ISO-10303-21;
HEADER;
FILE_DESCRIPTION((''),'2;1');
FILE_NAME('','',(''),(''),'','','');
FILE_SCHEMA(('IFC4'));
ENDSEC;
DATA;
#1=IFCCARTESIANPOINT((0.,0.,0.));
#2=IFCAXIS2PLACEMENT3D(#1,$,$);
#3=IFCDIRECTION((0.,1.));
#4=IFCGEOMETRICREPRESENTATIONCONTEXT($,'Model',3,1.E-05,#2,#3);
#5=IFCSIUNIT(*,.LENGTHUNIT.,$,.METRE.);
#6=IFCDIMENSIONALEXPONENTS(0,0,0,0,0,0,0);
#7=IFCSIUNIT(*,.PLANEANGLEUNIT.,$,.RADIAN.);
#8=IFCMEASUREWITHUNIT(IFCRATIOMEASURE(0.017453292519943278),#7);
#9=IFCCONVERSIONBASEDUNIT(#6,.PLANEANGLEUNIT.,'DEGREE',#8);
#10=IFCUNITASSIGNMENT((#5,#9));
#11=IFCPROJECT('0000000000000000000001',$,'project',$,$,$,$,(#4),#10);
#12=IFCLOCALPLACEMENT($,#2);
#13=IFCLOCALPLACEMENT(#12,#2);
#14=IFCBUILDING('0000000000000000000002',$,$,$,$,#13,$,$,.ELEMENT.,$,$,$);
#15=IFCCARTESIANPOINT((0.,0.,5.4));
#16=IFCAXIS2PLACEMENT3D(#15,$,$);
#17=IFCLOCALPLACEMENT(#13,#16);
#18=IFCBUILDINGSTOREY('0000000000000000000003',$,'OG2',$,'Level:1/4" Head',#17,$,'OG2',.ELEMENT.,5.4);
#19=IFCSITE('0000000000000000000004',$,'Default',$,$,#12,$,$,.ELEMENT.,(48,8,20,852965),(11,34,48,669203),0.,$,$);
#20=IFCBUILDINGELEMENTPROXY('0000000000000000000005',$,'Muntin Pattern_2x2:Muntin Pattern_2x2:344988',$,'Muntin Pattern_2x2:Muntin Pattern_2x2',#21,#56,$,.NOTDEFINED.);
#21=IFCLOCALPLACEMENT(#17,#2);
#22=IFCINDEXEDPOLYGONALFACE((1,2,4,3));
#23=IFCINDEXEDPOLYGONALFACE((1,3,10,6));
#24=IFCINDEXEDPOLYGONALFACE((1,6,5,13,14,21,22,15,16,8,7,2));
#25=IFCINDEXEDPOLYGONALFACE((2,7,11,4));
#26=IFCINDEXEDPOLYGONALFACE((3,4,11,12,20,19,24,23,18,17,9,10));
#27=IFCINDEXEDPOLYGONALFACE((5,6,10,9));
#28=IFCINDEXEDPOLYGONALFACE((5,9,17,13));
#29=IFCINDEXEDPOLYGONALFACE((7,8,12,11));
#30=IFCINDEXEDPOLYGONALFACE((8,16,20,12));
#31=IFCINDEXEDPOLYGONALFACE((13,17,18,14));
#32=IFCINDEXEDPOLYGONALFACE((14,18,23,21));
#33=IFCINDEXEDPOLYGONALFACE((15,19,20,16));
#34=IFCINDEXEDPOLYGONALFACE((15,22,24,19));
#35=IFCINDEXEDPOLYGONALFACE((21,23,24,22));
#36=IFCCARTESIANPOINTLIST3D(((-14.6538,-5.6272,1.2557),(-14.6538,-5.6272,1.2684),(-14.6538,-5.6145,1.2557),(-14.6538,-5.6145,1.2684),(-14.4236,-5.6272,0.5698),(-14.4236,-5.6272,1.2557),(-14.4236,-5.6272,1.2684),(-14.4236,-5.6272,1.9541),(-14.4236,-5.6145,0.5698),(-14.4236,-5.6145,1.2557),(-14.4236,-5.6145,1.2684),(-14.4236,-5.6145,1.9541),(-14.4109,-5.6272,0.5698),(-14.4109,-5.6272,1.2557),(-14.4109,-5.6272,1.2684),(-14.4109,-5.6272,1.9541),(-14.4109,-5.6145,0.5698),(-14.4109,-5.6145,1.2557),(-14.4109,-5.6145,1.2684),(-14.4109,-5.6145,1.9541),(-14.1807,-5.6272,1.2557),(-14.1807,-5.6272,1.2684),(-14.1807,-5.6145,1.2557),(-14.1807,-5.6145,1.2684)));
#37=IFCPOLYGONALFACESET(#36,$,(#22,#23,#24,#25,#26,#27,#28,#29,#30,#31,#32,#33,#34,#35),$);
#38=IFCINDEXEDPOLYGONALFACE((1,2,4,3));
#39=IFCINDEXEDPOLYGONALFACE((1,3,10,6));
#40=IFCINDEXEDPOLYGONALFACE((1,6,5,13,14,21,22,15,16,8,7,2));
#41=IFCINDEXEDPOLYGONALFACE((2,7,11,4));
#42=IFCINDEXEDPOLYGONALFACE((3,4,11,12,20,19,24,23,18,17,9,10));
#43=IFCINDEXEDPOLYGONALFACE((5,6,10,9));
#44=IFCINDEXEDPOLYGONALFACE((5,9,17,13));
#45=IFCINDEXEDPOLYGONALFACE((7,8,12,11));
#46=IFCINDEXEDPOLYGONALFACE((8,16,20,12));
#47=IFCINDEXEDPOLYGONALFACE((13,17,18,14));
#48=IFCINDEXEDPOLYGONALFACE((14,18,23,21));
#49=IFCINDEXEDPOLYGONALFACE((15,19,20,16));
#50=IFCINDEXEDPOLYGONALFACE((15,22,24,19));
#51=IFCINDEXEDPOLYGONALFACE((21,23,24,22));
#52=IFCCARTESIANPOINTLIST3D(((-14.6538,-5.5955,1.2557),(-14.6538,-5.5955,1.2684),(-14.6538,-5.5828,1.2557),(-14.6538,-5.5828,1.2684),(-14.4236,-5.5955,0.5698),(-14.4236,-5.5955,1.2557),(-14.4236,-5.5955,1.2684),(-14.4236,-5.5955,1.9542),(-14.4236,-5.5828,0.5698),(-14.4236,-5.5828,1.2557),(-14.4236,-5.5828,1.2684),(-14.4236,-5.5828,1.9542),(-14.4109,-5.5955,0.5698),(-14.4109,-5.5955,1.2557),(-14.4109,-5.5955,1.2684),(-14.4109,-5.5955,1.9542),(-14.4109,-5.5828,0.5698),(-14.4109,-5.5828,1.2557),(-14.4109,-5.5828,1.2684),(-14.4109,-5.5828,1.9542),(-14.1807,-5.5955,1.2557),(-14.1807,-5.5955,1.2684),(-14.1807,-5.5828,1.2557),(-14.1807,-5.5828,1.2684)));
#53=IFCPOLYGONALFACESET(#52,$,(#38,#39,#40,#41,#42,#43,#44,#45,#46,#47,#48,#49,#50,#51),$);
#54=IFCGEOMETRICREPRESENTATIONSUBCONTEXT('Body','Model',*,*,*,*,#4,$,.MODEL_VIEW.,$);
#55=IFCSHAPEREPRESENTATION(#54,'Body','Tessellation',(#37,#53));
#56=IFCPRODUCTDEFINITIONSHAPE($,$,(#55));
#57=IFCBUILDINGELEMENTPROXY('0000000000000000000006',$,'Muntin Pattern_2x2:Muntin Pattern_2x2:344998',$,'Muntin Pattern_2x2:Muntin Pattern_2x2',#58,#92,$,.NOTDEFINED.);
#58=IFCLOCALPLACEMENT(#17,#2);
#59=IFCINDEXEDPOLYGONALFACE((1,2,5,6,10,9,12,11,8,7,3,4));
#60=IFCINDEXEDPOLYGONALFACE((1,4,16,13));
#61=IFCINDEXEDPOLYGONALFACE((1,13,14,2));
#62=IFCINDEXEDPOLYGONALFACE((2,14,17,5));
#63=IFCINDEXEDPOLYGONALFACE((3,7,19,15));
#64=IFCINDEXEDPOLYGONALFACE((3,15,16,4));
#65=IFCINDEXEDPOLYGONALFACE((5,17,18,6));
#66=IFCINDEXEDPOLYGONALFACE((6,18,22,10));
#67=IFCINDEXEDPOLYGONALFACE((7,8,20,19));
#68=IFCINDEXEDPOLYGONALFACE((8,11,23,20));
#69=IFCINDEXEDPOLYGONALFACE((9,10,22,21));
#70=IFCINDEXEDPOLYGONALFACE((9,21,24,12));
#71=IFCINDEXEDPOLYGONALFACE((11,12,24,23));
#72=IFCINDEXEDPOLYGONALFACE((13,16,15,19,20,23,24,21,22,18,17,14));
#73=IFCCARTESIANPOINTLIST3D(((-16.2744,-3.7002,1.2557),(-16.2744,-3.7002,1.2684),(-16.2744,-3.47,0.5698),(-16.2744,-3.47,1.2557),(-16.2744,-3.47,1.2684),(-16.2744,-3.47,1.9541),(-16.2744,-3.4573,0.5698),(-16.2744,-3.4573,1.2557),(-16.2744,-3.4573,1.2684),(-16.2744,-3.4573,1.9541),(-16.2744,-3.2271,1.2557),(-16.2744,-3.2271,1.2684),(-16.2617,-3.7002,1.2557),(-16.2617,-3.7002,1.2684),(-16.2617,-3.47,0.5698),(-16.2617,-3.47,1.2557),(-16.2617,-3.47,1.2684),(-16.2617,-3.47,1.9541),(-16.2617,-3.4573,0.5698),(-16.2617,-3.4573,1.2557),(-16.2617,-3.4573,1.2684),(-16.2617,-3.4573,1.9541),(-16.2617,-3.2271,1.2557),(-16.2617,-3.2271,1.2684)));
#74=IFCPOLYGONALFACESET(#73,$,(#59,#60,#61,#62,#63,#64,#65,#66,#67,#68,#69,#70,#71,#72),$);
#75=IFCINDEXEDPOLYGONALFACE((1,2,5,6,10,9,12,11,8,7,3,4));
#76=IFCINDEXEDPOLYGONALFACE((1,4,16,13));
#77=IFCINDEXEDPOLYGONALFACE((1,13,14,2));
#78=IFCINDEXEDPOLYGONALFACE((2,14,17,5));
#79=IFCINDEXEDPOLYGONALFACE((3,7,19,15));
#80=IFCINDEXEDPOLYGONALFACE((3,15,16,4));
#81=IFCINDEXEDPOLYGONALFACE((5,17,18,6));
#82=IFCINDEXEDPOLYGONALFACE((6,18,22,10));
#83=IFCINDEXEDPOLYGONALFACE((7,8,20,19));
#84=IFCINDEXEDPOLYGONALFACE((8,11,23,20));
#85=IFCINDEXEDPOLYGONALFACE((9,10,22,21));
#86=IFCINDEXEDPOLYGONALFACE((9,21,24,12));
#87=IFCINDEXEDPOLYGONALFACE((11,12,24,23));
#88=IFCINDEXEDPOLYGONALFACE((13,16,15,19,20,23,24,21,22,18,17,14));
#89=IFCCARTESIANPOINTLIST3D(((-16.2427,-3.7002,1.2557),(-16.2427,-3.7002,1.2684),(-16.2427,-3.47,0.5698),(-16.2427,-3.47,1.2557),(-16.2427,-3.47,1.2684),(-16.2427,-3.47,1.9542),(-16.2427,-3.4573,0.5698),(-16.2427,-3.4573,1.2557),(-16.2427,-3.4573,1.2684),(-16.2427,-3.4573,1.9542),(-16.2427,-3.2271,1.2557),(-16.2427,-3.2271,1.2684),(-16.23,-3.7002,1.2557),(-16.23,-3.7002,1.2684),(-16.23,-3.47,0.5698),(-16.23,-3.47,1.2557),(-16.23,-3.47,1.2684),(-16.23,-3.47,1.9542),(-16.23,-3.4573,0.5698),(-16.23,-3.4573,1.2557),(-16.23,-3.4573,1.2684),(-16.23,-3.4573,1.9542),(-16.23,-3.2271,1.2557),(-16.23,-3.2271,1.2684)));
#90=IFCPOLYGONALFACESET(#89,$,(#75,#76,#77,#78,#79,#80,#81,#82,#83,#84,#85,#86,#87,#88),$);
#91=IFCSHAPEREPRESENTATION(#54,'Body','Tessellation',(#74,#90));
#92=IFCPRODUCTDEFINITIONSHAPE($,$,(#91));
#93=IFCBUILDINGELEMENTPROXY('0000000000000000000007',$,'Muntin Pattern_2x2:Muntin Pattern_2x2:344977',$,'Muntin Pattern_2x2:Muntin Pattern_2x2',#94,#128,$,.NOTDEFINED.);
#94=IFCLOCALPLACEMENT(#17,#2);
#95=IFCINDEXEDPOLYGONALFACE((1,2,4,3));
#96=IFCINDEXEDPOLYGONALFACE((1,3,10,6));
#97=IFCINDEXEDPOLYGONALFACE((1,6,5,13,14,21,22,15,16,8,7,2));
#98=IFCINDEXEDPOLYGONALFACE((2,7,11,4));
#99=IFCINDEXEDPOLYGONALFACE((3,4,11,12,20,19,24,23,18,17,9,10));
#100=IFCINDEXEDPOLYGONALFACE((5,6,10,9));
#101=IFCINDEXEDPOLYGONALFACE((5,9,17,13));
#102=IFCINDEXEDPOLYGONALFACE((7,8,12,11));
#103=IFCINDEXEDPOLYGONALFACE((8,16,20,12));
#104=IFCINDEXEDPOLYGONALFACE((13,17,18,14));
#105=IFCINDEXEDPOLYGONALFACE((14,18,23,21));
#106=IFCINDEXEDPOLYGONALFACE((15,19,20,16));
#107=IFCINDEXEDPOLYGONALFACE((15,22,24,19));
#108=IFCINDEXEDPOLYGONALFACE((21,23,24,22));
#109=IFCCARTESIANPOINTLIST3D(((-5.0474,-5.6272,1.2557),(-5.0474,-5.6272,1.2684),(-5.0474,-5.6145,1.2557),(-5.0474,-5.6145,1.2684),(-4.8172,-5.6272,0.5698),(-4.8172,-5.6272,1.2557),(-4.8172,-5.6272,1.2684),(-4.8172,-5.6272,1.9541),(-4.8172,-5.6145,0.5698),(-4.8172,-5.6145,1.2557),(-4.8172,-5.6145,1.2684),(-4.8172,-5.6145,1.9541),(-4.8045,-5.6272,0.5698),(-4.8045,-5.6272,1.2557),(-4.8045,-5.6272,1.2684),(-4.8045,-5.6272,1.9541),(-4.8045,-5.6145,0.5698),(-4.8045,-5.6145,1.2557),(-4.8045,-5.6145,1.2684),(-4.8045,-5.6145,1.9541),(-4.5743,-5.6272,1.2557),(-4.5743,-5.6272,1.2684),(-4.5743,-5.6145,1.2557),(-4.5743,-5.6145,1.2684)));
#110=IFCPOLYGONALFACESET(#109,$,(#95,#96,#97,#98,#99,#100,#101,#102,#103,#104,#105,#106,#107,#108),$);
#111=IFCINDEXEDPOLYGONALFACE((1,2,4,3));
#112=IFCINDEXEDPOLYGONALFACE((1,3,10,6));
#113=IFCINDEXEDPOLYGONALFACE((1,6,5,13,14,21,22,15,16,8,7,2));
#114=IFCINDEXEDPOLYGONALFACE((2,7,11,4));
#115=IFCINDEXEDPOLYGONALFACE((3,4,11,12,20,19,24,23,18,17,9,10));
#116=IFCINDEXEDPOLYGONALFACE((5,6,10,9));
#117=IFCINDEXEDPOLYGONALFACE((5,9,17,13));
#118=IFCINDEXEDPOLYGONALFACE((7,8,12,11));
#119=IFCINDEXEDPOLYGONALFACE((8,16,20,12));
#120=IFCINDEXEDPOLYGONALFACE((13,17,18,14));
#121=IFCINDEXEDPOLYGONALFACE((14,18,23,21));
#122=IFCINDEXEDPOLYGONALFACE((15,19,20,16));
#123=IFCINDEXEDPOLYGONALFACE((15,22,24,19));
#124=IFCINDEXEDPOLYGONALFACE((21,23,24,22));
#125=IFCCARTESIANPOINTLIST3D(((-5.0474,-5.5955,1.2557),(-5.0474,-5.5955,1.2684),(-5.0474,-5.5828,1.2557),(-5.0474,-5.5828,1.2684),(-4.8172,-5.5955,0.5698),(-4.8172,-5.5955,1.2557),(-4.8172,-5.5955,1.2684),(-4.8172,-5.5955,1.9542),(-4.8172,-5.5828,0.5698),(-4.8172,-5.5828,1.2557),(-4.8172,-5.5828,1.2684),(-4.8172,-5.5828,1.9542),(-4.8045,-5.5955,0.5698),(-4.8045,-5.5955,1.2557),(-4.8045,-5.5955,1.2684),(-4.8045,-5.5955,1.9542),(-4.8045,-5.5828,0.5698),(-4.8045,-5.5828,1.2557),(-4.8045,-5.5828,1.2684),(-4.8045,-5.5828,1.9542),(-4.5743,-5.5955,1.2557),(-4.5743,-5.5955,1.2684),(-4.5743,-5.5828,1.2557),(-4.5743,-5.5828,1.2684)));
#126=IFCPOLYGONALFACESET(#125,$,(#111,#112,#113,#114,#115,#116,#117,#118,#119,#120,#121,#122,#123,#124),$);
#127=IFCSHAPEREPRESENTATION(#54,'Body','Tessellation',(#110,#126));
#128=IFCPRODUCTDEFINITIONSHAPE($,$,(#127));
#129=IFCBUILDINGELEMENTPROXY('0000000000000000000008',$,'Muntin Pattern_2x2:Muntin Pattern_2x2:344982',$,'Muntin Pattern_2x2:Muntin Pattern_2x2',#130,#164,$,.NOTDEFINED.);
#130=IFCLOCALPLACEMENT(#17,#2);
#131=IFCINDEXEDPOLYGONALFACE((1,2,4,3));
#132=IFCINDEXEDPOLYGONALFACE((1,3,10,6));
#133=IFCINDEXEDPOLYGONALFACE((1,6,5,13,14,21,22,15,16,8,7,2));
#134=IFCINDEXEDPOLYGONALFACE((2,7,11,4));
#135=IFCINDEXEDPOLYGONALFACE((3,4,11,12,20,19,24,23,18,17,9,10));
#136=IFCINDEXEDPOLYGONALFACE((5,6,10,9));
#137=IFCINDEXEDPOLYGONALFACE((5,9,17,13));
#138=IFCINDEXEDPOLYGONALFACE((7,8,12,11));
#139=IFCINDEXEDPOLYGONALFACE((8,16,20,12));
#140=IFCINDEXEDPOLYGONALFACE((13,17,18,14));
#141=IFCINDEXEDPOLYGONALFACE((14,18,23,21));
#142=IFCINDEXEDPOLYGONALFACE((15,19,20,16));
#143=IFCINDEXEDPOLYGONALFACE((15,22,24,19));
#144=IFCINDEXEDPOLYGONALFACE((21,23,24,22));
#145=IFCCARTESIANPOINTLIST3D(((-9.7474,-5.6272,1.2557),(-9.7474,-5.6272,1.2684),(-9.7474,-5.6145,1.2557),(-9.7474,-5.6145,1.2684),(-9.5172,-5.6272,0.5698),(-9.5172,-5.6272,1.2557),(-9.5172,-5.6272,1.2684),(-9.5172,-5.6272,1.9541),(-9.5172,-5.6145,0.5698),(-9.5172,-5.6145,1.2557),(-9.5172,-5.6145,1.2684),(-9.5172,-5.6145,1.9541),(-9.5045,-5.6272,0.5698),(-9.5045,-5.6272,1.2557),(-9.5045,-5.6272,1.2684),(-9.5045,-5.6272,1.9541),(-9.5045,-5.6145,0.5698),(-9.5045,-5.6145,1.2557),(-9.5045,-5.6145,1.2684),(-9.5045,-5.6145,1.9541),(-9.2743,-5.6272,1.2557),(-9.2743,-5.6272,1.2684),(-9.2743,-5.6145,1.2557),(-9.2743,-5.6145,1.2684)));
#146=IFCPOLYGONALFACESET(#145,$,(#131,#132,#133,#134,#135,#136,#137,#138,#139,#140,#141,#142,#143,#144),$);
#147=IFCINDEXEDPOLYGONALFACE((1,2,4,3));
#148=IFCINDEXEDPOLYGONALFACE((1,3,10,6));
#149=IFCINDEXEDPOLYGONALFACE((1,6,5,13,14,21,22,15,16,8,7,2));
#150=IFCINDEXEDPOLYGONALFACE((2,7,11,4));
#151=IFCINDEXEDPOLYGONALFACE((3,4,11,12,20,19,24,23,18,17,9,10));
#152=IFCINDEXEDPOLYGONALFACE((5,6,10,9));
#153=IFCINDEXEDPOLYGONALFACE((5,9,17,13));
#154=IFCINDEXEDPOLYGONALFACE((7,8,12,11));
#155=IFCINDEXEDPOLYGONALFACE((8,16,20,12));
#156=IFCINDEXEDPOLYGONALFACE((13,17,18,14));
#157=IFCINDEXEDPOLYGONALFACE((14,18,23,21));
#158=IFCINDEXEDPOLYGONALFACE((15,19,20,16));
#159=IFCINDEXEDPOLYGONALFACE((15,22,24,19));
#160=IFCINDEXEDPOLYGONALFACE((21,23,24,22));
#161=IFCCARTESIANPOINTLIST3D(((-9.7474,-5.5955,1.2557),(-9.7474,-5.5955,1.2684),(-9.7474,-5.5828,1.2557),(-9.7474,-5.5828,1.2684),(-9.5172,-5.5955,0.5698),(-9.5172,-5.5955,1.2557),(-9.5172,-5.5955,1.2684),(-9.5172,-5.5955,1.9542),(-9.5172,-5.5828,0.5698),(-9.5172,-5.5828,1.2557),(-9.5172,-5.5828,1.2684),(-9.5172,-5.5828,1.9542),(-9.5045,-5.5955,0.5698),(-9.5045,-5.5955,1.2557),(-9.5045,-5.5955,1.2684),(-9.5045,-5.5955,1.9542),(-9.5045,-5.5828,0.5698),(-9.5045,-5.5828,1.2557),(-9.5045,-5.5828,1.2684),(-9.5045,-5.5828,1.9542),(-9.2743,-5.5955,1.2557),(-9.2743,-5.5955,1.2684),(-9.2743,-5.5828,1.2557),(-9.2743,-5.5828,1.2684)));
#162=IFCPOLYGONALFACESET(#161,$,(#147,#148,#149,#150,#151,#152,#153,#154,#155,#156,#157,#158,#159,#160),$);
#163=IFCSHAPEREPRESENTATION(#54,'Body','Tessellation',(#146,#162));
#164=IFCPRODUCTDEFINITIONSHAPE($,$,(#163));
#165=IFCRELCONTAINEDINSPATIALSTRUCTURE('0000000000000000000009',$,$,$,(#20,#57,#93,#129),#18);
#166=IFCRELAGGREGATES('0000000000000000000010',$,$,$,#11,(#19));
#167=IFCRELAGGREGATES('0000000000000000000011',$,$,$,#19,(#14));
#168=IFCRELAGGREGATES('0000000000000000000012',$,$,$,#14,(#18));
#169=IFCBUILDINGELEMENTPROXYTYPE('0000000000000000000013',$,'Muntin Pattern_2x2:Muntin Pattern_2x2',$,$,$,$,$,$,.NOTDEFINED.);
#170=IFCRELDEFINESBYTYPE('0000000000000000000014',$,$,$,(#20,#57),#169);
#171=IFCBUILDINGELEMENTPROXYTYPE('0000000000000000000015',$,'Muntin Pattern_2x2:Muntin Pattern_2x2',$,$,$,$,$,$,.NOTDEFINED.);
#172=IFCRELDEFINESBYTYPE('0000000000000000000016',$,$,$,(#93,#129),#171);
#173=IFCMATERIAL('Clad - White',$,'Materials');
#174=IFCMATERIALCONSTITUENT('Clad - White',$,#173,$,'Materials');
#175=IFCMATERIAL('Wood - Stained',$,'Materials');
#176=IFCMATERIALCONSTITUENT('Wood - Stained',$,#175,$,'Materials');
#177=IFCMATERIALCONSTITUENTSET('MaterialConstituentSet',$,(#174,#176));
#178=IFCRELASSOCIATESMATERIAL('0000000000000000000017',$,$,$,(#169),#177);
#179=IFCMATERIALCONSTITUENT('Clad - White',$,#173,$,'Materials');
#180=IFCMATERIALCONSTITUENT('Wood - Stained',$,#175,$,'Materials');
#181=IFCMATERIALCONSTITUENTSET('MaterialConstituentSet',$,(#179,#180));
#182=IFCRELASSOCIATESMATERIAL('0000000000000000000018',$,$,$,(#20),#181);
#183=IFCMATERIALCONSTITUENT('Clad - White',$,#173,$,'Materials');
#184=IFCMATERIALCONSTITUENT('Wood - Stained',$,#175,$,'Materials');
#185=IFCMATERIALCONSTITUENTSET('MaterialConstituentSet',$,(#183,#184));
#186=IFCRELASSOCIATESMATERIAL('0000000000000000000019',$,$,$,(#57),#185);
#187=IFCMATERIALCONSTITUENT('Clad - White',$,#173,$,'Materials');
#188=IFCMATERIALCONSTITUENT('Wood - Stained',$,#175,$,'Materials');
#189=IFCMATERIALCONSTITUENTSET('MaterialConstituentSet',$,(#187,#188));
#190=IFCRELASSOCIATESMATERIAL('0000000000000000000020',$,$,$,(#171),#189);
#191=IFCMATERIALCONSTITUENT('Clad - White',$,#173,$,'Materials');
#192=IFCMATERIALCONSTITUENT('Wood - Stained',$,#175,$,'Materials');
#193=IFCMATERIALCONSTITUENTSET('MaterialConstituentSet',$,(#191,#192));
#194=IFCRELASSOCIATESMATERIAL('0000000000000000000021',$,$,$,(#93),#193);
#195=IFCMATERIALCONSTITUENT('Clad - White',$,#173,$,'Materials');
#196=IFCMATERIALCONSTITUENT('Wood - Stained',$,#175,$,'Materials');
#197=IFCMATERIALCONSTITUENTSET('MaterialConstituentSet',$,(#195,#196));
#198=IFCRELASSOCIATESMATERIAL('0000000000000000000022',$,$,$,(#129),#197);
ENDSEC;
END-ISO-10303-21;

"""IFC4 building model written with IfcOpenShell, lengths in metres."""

from ifc_helpers import new_model, entity, si_unit, converted_unit, direction, frame, origin, place, context, subcontext, project, spatial, indexed_curve, outline, extrude, source, transform, mapped, material, constituent, constituent_set, type_object, type_shapes, element, save


model = new_model("IFC4")

# Units and contexts
model_context = context("Model", 3, precision=1e-05, world=origin(), true_north=direction((0.0, 1.0)))
body_context = subcontext(model_context, "Body", "Model", "MODEL_VIEW")
ifc_project = project(units=[si_unit("LENGTHUNIT", "METRE"), converted_unit("PLANEANGLEUNIT", "DEGREE", entity("IfcRatioMeasure", 0.017453292519943278), si_unit("PLANEANGLEUNIT", "RADIAN"), dimensions=[0, 0, 0, 0, 0, 0, 0])], contexts=[model_context])

# Site, building, storey
site_placement = place(None, origin())
site = spatial("IfcSite", under=ifc_project, at=site_placement, Name="Default", CompositionType="ELEMENT", RefLatitude=(48, 8, 20, 852965), RefLongitude=(11, 34, 48, 669203), RefElevation=0.0)
building_placement = place(site_placement, origin())
building = spatial("IfcBuilding", under=site, at=building_placement, CompositionType="ELEMENT")
storey_placement = place(building_placement, frame((0.0, 0.0, 5.4)))
storey = spatial("IfcBuildingStorey", under=building, at=storey_placement, Name="OG2", ObjectType="Level:1/4\" Head", LongName="OG2", CompositionType="ELEMENT", Elevation=5.4)

# Building element proxies
ifc_material_1 = material(Name="Clad - White", Category="Materials")
ifc_material_2 = material(Name="Wood - Stained", Category="Materials")
ifc_constituent_1 = constituent(ifc_material_1, Name="Clad - White", Category="Materials")
ifc_constituent_2 = constituent(ifc_material_2, Name="Wood - Stained", Category="Materials")
ifc_constituent_set_1 = constituent_set(constituents=[ifc_constituent_1, ifc_constituent_2], Name="MaterialConstituentSet")
building_element_proxy_type_1 = type_object("IfcBuildingElementProxyType", Name="Muntin Pattern_2x2:Muntin Pattern_2x2", PredefinedType="NOTDEFINED", material=ifc_constituent_set_1)
shared_shape_1 = source(origin(), body_context, "Body", "SweptSolid", [
    extrude(outline(indexed_curve([(0.0064, -0.0064), (0.6921, -0.0064), (0.6921, 0.0063), (0.0064, 0.0063), (0.0064, 0.2365), (-0.0063, 0.2365), (-0.0063, 0.0063), (-0.6922, 0.0063), (-0.6922, -0.0064), (-0.0063, -0.0064), (-0.0063, -0.2365), (0.0064, -0.2365), (0.0064, -0.0064)], self_intersect=False)), frame((0.0, -0.0222, 0.6921), z_axis=(0.0, 1.0, 0.0), x_axis=(0.0, 0.0, 1.0)), (0.0, 0.0, 1.0), 0.0127),
    extrude(outline(indexed_curve([(0.0064, -0.0064), (0.6922, -0.0064), (0.6922, 0.0063), (0.0064, 0.0063), (0.0064, 0.2365), (-0.0063, 0.2365), (-0.0063, 0.0063), (-0.6922, 0.0063), (-0.6922, -0.0064), (-0.0063, -0.0064), (-0.0063, -0.2365), (0.0064, -0.2365), (0.0064, -0.0064)], self_intersect=False)), frame((0.0, 0.0095, 0.6922), z_axis=(0.0, 1.0, 0.0), x_axis=(0.0, 0.0, 1.0)), (0.0, 0.0, 1.0), 0.0127),
])
type_shapes(building_element_proxy_type_1, [shared_shape_1])
ifc_constituent_3 = constituent(ifc_material_1, Name="Clad - White", Category="Materials")
ifc_constituent_4 = constituent(ifc_material_2, Name="Wood - Stained", Category="Materials")
ifc_constituent_set_2 = constituent_set(constituents=[ifc_constituent_3, ifc_constituent_4], Name="MaterialConstituentSet")
proxy_1_placement = place(storey_placement, frame((-14.4173, -5.605, 0.5699)))
element("IfcBuildingElementProxy", 1, at=proxy_1_placement, inside=storey, type_object=building_element_proxy_type_1, material=ifc_constituent_set_2, Name="Muntin Pattern_2x2:Muntin Pattern_2x2:344988", ObjectType="Muntin Pattern_2x2:Muntin Pattern_2x2", PredefinedType="NOTDEFINED", context=body_context, shape_type="MappedRepresentation", body=[
    mapped(shared_shape_1, transform((0.0, 0.0, 0.0), scale=1.0)),
])
ifc_constituent_5 = constituent(ifc_material_1, Name="Clad - White", Category="Materials")
ifc_constituent_6 = constituent(ifc_material_2, Name="Wood - Stained", Category="Materials")
ifc_constituent_set_3 = constituent_set(constituents=[ifc_constituent_5, ifc_constituent_6], Name="MaterialConstituentSet")
proxy_2_placement = place(storey_placement, frame((-16.2522, -3.4636, 0.5699), z_axis=(0.0, 0.0, 1.0), x_axis=(0.0, -1.0, 0.0)))
element("IfcBuildingElementProxy", 2, at=proxy_2_placement, inside=storey, type_object=building_element_proxy_type_1, material=ifc_constituent_set_3, Name="Muntin Pattern_2x2:Muntin Pattern_2x2:344998", ObjectType="Muntin Pattern_2x2:Muntin Pattern_2x2", PredefinedType="NOTDEFINED", context=body_context, shape_type="MappedRepresentation", body=[
    mapped(shared_shape_1, transform((0.0, 0.0, 0.0), scale=1.0)),
])
ifc_constituent_7 = constituent(ifc_material_1, Name="Clad - White", Category="Materials")
ifc_constituent_8 = constituent(ifc_material_2, Name="Wood - Stained", Category="Materials")
ifc_constituent_set_4 = constituent_set(constituents=[ifc_constituent_7, ifc_constituent_8], Name="MaterialConstituentSet")
ifc_constituent_9 = constituent(ifc_material_1, Name="Clad - White", Category="Materials")
ifc_constituent_10 = constituent(ifc_material_2, Name="Wood - Stained", Category="Materials")
ifc_constituent_set_5 = constituent_set(constituents=[ifc_constituent_9, ifc_constituent_10], Name="MaterialConstituentSet")
building_element_proxy_type_2 = type_object("IfcBuildingElementProxyType", Name="Muntin Pattern_2x2:Muntin Pattern_2x2", PredefinedType="NOTDEFINED", material=ifc_constituent_set_5)
shared_shape_2 = source(origin(), body_context, "Body", "SweptSolid", [
    extrude(outline(indexed_curve([(0.0064, -0.0064), (0.6921, -0.0064), (0.6921, 0.0063), (0.0064, 0.0063), (0.0064, 0.2365), (-0.0063, 0.2365), (-0.0063, 0.0063), (-0.6922, 0.0063), (-0.6922, -0.0064), (-0.0063, -0.0064), (-0.0063, -0.2365), (0.0064, -0.2365), (0.0064, -0.0064)], self_intersect=False)), frame((0.0, 0.0095, 0.6921), z_axis=(0.0, 1.0, 0.0), x_axis=(0.0, 0.0, 1.0)), (0.0, 0.0, 1.0), 0.0127),
    extrude(outline(indexed_curve([(0.0064, -0.0064), (0.6922, -0.0064), (0.6922, 0.0063), (0.0064, 0.0063), (0.0064, 0.2365), (-0.0063, 0.2365), (-0.0063, 0.0063), (-0.6922, 0.0063), (-0.6922, -0.0064), (-0.0063, -0.0064), (-0.0063, -0.2365), (0.0064, -0.2365), (0.0064, -0.0064)], self_intersect=False)), frame((0.0, -0.0222, 0.6922), z_axis=(0.0, 1.0, 0.0), x_axis=(0.0, 0.0, 1.0)), (0.0, 0.0, 1.0), 0.0127),
])
type_shapes(building_element_proxy_type_2, [shared_shape_2])
proxy_3_placement = place(storey_placement, frame((-4.8108, -5.605, 0.5699), z_axis=(0.0, 0.0, 1.0), x_axis=(-1.0, 0.0, 0.0)))
element("IfcBuildingElementProxy", 3, at=proxy_3_placement, inside=storey, type_object=building_element_proxy_type_2, material=ifc_constituent_set_4, Name="Muntin Pattern_2x2:Muntin Pattern_2x2:344977", ObjectType="Muntin Pattern_2x2:Muntin Pattern_2x2", PredefinedType="NOTDEFINED", context=body_context, shape_type="MappedRepresentation", body=[
    mapped(shared_shape_2, transform((0.0, 0.0, 0.0), scale=1.0)),
])
ifc_constituent_11 = constituent(ifc_material_1, Name="Clad - White", Category="Materials")
ifc_constituent_12 = constituent(ifc_material_2, Name="Wood - Stained", Category="Materials")
ifc_constituent_set_6 = constituent_set(constituents=[ifc_constituent_11, ifc_constituent_12], Name="MaterialConstituentSet")
proxy_4_placement = place(storey_placement, frame((-9.5108, -5.605, 0.5699), z_axis=(0.0, 0.0, 1.0), x_axis=(-1.0, 0.0, 0.0)))
element("IfcBuildingElementProxy", 4, at=proxy_4_placement, inside=storey, type_object=building_element_proxy_type_2, material=ifc_constituent_set_6, Name="Muntin Pattern_2x2:Muntin Pattern_2x2:344982", ObjectType="Muntin Pattern_2x2:Muntin Pattern_2x2", PredefinedType="NOTDEFINED", context=body_context, shape_type="MappedRepresentation", body=[
    mapped(shared_shape_2, transform((0.0, 0.0, 0.0), scale=1.0)),
])

save(model, "model.ifc")
